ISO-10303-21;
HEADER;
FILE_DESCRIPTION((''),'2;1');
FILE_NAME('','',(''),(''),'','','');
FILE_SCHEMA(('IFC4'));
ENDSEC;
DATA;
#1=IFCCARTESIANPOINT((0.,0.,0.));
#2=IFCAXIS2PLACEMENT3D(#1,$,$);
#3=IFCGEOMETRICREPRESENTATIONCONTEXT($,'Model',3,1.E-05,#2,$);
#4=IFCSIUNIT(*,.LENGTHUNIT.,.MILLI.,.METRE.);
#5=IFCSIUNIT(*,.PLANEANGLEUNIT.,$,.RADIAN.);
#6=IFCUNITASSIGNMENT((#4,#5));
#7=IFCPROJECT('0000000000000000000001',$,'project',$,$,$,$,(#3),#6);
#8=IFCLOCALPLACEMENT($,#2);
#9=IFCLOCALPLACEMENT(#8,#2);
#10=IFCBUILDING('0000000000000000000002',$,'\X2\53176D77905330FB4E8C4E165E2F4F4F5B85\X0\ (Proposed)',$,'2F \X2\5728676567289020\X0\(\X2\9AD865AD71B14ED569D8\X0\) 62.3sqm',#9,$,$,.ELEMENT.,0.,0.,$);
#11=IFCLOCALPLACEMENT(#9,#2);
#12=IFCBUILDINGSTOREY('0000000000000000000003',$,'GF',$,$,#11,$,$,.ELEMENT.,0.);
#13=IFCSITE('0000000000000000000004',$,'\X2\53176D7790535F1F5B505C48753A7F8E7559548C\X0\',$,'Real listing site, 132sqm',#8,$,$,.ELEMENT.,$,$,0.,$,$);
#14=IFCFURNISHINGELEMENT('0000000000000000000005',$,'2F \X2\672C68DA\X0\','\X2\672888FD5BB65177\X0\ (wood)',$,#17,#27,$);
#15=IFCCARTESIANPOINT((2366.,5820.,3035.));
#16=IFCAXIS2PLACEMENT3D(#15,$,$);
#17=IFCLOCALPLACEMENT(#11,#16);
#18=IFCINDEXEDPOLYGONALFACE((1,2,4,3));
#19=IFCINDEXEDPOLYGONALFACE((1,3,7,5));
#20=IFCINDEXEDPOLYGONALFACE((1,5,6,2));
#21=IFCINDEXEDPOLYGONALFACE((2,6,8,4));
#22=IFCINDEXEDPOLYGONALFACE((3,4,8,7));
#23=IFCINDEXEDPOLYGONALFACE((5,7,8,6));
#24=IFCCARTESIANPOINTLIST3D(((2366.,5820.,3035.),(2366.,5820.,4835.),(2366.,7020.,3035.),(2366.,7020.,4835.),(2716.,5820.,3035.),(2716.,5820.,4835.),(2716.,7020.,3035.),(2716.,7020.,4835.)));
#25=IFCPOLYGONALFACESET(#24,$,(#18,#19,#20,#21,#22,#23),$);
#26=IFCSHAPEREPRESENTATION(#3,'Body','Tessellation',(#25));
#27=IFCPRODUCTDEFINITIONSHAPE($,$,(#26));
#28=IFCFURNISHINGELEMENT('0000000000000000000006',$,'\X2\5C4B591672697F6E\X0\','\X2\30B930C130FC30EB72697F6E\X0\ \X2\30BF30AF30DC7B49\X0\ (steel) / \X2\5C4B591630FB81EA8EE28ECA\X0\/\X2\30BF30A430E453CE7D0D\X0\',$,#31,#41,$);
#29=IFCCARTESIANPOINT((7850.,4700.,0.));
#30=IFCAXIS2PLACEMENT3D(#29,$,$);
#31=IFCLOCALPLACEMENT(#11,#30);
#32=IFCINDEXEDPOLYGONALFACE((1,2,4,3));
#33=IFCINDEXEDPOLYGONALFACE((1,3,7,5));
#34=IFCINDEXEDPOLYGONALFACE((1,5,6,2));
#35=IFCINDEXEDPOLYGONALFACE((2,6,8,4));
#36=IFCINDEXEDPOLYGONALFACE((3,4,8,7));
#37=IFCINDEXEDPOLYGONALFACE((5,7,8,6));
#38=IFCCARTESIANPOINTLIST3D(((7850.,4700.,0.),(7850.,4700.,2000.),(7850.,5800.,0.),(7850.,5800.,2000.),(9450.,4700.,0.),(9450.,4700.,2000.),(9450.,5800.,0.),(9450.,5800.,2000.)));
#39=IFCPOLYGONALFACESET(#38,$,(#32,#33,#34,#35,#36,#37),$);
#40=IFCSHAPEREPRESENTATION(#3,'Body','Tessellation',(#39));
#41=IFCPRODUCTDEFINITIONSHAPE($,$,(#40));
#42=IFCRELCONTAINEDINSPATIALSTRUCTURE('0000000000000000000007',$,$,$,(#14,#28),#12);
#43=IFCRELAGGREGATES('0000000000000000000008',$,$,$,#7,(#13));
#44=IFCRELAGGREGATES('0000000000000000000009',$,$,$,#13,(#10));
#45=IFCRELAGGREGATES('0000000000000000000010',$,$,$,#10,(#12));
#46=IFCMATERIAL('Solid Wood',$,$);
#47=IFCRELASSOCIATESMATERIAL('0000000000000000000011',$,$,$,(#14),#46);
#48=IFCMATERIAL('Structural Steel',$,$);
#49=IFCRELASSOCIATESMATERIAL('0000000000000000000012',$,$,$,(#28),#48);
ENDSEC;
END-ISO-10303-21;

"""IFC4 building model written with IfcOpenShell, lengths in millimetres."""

from ifc_helpers import new_model, si_unit, frame, frame_2d, origin, place, context, project, spatial, rectangle, extrude, material, element, save


model = new_model("IFC4")

# Units and contexts
model_context = context("Model", 3, precision=1e-05, world=origin())
ifc_project = project(units=[si_unit("LENGTHUNIT", "METRE", prefix="MILLI"), si_unit("PLANEANGLEUNIT", "RADIAN")], contexts=[model_context])

# Site, building, storey
site_placement = place(None, origin())
site = spatial("IfcSite", under=ifc_project, at=site_placement, Name="北海道弟子屈町美留和", ObjectType="Real listing site, 132sqm", CompositionType="ELEMENT", RefElevation=0.0)
building_placement = place(site_placement, origin())
building = spatial("IfcBuilding", under=site, at=building_placement, Name="北海道・二世帯住宅 (Proposed)", ObjectType="2F 在来木造(高断熱仕様) 62.3sqm", CompositionType="ELEMENT", ElevationOfRefHeight=0.0, ElevationOfTerrain=0.0)
storey_placement = place(building_placement, origin())
storey = spatial("IfcBuildingStorey", under=building, at=storey_placement, Name="GF", CompositionType="ELEMENT", Elevation=0.0)

# Shared definitions
ifc_material_1 = material(Name="Solid Wood")

# Shared definitions
ifc_material_2 = material(Name="Structural Steel")

# Furnishing elements
furnishing_1_placement = place(storey_placement, frame((2366.0, 5820.0, 3035.0)))
element("IfcFurnishingElement", 1, at=furnishing_1_placement, inside=storey, material=ifc_material_1, Name="2F 本棚", Description="木製家具 (wood)", context=model_context, shape_type="SweptSolid", body=[
    extrude(rectangle(XDim=350.0, YDim=1200.0, at=frame_2d((175.0, 600.0))), frame((2366.0, 5820.0, 3035.0)), (0.0, 0.0, 1.0), 1800.0),
])
furnishing_2_placement = place(storey_placement, frame((7850.0, 4700.0, 0.0)))
element("IfcFurnishingElement", 2, at=furnishing_2_placement, inside=storey, material=ifc_material_2, Name="屋外物置", Description="スチール物置 タクボ等 (steel) / 屋外・自転車/タイヤ収納", context=model_context, shape_type="SweptSolid", body=[
    extrude(rectangle(XDim=1600.0, YDim=1100.0, at=frame_2d((800.0, 550.0))), frame((7850.0, 4700.0, 0.0)), (0.0, 0.0, 1.0), 2000.0),
])

save(model, "model.ifc")
